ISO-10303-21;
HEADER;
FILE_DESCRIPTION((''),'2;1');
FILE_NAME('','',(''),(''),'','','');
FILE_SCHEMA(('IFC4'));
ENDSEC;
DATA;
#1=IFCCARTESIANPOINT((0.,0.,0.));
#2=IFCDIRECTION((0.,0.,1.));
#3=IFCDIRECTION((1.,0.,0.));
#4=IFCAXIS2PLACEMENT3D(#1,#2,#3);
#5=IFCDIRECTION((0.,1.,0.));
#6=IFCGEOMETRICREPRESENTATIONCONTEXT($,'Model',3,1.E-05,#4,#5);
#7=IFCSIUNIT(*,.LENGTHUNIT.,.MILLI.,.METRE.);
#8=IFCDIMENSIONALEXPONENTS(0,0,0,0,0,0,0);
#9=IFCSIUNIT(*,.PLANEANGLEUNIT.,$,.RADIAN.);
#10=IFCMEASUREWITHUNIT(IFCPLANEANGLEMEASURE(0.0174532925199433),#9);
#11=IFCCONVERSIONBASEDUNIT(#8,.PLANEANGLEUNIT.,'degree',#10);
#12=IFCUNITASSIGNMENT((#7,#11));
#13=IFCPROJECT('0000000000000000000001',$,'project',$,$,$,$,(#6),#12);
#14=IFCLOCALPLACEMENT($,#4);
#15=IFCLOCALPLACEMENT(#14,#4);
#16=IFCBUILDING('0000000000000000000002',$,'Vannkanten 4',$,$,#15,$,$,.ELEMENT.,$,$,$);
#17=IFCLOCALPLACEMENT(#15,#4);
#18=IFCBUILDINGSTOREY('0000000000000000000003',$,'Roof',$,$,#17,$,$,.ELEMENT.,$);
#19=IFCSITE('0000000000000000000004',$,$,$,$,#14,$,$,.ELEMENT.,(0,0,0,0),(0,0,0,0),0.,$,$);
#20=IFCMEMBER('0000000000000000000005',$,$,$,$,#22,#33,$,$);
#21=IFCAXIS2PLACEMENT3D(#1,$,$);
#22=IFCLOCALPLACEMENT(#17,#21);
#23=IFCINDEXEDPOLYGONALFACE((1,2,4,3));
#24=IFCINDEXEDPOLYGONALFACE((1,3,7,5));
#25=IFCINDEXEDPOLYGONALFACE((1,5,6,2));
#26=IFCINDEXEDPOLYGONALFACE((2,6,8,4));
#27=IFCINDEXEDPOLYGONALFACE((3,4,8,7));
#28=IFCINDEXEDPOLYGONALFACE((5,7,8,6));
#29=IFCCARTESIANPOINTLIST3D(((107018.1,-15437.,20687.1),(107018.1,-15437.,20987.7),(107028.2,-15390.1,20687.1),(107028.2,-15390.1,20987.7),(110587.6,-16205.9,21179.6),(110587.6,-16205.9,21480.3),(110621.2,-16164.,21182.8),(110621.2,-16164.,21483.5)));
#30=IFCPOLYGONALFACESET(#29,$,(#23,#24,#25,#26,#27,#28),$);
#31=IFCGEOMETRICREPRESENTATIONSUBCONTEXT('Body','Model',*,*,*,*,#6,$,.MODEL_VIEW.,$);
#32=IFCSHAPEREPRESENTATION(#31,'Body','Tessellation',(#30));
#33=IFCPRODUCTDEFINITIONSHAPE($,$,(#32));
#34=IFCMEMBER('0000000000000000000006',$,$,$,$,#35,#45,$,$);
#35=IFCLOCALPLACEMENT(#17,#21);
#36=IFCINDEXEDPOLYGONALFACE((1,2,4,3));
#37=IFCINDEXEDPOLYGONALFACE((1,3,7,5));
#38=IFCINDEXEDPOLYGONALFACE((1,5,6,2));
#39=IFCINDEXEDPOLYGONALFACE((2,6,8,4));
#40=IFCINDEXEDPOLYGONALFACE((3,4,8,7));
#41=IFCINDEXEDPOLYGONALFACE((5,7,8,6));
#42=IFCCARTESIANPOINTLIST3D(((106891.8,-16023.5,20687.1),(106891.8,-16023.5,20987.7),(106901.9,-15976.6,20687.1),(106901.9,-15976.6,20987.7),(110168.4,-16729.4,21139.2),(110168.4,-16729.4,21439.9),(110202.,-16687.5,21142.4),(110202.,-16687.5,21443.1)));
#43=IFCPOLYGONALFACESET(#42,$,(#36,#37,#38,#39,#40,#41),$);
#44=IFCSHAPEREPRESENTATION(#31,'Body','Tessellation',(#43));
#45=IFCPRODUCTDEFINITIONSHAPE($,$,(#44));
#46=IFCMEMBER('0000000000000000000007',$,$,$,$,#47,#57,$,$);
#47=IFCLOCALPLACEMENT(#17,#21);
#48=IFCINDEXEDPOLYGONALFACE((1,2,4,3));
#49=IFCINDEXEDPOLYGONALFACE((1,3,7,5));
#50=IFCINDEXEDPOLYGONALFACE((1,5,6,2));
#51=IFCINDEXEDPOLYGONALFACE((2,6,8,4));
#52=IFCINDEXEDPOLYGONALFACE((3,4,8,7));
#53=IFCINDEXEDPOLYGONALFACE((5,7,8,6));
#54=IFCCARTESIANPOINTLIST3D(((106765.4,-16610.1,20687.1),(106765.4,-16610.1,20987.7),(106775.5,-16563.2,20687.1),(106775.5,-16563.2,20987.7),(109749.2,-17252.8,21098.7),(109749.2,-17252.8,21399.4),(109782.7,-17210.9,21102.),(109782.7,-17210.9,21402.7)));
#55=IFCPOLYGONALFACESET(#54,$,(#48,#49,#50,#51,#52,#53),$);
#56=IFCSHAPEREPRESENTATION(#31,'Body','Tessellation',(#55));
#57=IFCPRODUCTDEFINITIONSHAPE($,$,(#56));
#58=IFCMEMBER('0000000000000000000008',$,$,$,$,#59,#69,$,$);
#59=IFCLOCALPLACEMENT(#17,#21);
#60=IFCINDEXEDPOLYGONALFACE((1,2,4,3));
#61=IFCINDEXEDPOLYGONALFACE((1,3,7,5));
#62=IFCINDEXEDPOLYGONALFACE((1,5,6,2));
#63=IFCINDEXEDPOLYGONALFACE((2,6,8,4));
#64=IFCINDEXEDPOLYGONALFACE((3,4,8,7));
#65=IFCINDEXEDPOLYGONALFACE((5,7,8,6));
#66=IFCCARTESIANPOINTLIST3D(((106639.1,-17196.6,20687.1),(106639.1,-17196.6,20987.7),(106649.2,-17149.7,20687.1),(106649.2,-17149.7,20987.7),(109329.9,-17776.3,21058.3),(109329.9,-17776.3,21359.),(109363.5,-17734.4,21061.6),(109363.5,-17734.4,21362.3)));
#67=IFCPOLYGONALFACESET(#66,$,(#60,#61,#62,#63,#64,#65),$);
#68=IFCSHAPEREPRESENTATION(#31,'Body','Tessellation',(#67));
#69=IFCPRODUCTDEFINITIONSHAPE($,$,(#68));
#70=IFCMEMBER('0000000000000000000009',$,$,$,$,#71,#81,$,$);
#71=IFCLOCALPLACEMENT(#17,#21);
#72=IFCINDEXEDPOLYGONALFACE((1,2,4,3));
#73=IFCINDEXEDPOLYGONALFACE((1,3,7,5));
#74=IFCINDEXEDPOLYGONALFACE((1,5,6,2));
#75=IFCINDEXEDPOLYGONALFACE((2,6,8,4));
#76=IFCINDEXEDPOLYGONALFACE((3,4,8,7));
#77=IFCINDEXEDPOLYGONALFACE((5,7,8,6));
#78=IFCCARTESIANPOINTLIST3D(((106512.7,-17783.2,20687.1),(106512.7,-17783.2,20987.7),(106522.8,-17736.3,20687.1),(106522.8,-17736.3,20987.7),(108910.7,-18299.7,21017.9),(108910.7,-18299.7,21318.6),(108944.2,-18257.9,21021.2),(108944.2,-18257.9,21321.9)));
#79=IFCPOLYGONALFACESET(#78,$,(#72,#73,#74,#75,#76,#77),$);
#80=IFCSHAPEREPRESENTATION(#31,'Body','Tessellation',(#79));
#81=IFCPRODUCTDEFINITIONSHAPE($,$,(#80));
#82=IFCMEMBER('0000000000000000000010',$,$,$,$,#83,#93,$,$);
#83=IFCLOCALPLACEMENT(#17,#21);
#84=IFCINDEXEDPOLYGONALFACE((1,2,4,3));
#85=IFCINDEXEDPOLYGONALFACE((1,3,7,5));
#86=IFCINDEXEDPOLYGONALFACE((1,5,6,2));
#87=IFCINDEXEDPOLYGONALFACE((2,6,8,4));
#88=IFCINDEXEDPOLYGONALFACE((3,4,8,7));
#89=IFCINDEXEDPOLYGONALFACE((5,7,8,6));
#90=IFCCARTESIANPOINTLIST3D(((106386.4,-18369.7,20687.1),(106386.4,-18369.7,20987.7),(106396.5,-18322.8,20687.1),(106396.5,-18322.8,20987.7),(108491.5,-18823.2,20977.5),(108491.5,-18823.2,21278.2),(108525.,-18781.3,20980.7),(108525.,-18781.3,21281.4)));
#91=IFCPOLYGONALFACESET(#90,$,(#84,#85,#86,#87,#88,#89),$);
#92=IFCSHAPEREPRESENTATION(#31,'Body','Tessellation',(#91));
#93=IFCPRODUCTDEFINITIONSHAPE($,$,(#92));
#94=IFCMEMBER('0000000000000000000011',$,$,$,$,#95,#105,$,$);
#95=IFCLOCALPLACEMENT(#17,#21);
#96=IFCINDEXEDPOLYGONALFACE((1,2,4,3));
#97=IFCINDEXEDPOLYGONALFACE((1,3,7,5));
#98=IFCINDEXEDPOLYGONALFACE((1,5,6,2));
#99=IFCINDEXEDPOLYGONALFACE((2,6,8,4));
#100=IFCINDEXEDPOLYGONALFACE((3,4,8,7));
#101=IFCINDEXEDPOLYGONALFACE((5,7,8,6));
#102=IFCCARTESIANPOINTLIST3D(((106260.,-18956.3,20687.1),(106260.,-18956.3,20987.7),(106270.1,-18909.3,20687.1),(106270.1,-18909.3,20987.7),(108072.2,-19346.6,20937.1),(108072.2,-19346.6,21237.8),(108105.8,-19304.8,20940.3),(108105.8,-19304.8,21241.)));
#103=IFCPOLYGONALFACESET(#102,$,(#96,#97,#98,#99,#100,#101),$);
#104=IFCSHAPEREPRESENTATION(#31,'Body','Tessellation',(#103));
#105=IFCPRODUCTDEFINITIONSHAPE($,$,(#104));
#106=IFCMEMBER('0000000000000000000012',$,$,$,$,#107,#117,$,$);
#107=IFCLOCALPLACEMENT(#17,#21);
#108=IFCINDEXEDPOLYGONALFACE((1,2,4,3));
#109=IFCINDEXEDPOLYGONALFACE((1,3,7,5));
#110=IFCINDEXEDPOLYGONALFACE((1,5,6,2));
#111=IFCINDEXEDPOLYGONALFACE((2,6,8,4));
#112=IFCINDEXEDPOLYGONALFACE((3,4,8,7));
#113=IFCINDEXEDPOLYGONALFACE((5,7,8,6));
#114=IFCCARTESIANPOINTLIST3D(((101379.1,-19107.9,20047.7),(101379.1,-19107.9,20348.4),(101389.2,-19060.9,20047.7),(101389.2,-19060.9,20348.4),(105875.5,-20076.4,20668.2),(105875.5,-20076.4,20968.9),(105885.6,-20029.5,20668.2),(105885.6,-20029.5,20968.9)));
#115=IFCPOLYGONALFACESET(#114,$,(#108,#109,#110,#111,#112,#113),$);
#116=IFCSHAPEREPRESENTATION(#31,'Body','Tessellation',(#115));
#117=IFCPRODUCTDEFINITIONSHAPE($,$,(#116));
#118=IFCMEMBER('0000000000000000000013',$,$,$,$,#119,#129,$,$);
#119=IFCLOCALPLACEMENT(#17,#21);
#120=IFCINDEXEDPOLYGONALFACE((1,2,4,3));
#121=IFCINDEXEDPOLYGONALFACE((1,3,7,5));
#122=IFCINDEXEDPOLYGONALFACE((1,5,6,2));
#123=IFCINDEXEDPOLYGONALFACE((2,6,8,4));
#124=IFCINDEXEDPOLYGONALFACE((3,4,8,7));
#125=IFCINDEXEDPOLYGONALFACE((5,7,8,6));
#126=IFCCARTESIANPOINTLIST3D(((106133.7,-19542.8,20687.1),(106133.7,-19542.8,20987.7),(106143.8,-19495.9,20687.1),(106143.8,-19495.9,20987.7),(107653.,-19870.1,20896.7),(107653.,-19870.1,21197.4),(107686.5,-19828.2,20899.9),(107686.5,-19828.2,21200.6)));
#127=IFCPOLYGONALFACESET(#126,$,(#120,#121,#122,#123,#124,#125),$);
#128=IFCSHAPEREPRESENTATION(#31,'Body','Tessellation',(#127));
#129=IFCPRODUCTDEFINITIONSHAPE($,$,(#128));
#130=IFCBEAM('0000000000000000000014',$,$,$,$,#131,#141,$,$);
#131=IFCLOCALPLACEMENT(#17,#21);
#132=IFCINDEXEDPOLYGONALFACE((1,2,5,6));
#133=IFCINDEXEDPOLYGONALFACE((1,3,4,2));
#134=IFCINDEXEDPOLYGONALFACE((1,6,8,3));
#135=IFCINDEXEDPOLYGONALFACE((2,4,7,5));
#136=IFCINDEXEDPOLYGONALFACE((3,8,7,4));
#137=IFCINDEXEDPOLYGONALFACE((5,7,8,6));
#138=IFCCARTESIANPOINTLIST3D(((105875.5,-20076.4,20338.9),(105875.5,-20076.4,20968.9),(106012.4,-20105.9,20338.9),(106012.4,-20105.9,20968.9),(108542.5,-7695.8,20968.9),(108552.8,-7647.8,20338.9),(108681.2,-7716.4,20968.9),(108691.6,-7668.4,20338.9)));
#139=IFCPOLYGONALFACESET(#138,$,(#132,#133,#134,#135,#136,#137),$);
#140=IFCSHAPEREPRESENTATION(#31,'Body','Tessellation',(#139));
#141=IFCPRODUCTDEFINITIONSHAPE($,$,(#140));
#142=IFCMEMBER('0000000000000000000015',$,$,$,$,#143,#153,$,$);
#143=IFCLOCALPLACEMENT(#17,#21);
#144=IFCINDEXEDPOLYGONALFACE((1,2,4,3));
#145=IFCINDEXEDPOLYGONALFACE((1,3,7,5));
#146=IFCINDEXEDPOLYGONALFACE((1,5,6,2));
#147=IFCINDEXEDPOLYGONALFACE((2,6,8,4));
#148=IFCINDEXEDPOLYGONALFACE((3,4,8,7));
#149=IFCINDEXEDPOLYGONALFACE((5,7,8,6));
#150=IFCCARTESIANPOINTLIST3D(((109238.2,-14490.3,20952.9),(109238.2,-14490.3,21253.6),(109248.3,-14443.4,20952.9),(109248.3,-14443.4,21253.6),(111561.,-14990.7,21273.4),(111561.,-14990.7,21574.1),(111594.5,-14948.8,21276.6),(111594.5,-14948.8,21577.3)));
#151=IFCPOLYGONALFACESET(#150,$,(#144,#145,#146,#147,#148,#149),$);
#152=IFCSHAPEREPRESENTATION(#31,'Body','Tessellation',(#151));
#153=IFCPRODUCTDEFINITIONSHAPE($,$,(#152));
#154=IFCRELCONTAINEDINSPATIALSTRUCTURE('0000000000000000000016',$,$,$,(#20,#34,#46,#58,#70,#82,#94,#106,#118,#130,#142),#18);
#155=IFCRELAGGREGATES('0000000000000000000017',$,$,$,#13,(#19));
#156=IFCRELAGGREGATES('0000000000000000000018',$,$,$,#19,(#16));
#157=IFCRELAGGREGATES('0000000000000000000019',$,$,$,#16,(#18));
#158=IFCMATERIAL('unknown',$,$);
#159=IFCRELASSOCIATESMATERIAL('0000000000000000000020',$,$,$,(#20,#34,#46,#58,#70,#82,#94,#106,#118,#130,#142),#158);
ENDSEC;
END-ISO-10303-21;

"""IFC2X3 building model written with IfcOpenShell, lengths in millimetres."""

from ifc_helpers import new_model, entity, si_unit, converted_unit, direction, frame, origin_with_axes, place, context, subcontext, project, spatial, polyline, segment, composite_curve, outline, extrude, clip, halfspace, material, element, save


model = new_model("IFC2X3")

# Units and contexts
model_context = context("Model", 3, precision=1e-05, world=origin_with_axes(), true_north=direction((0.0, 1.0, 0.0)))
body_context = subcontext(model_context, "Body", "Model", "MODEL_VIEW")
ifc_project = project(units=[si_unit("LENGTHUNIT", "METRE", prefix="MILLI"), converted_unit("PLANEANGLEUNIT", "degree", entity("IfcPlaneAngleMeasure", 0.0174532925199433), si_unit("PLANEANGLEUNIT", "RADIAN"), dimensions=[0, 0, 0, 0, 0, 0, 0])], contexts=[model_context])

# Site, building, storey
site_placement = place(None, origin_with_axes())
site = spatial("IfcSite", under=ifc_project, at=site_placement, CompositionType="ELEMENT", RefLatitude=(0, 0, 0, 0), RefLongitude=(0, 0, 0, 0), RefElevation=0.0)
building_placement = place(site_placement, origin_with_axes())
building = spatial("IfcBuilding", under=site, at=building_placement, Name="Vannkanten 4", CompositionType="ELEMENT")
storey_placement = place(building_placement, origin_with_axes())
storey = spatial("IfcBuildingStorey", under=building, at=storey_placement, Name="Roof", CompositionType="ELEMENT")

# Members
ifc_material = material(Name="unknown")
member_1_placement = place(storey_placement, frame((107023.2, -15413.5, 20837.4), z_axis=(0.968803, -0.208692, 0.133675), x_axis=(0.210582, 0.977576, 0.0)))
element("IfcMember", 1, at=member_1_placement, inside=storey, material=ifc_material, context=body_context, shape_type="Clipping", body=[
    clip(clip(extrude(outline(composite_curve([segment(polyline([(-24.0, -149.0), (-24.0, 149.0), (24.0, 149.0), (24.0, -149.0), (-24.0, -149.0)]), True, "CONTINUOUS")], self_intersect=False)), frame((0.0, 0.0, -1894.5), z_axis=(0.0, 0.0, 1.0), x_axis=(1.0, 0.0, 0.0)), (0.0, 0.0, 1.0), 7497.7), halfspace(frame((-24.0, 149.0, 20.1), z_axis=(0.0, -0.133675, 0.991025), x_axis=(0.0, 0.991025, 0.133675)), True)), halfspace(frame((24.0, 149.0, 3728.8), z_axis=(0.446741, 0.119594, -0.886634), x_axis=(-0.893044, 0.0, -0.44997)), True)),
])
member_2_placement = place(storey_placement, frame((106896.8, -16000.1, 20837.4), z_axis=(0.968803, -0.208692, 0.133675), x_axis=(0.210582, 0.977576, 0.0)))
element("IfcMember", 2, at=member_2_placement, inside=storey, material=ifc_material, context=body_context, shape_type="Clipping", body=[
    clip(clip(extrude(outline(composite_curve([segment(polyline([(-24.0, -149.0), (-24.0, 149.0), (24.0, 149.0), (24.0, -149.0), (-24.0, -149.0)]), True, "CONTINUOUS")], self_intersect=False)), frame((0.0, 0.0, -1743.4), z_axis=(0.0, 0.0, 1.0), x_axis=(1.0, 0.0, 0.0)), (0.0, 0.0, 1.0), 6893.1), halfspace(frame((-24.0, 149.0, 20.1), z_axis=(0.0, -0.133675, 0.991025), x_axis=(0.0, 0.991025, 0.133675)), True)), halfspace(frame((24.0, 149.0, 3426.4), z_axis=(0.446741, 0.119594, -0.886634), x_axis=(-0.893044, 0.0, -0.44997)), True)),
])
member_3_placement = place(storey_placement, frame((106770.5, -16586.6, 20837.4), z_axis=(0.968803, -0.208692, 0.133675), x_axis=(0.210582, 0.977576, 0.0)))
element("IfcMember", 3, at=member_3_placement, inside=storey, material=ifc_material, context=body_context, shape_type="Clipping", body=[
    clip(clip(extrude(outline(composite_curve([segment(polyline([(-24.0, -149.0), (-24.0, 149.0), (24.0, 149.0), (24.0, -149.0), (-24.0, -149.0)]), True, "CONTINUOUS")], self_intersect=False)), frame((0.0, 0.0, -1592.2), z_axis=(0.0, 0.0, 1.0), x_axis=(1.0, 0.0, 0.0)), (0.0, 0.0, 1.0), 6288.4), halfspace(frame((-24.0, 149.0, 20.1), z_axis=(0.0, -0.133675, 0.991025), x_axis=(0.0, 0.991025, 0.133675)), True)), halfspace(frame((24.0, 149.0, 3124.1), z_axis=(0.446741, 0.119594, -0.886634), x_axis=(-0.893044, 0.0, -0.44997)), True)),
])
member_4_placement = place(storey_placement, frame((106644.1, -17173.2, 20837.4), z_axis=(0.968803, -0.208692, 0.133675), x_axis=(0.210582, 0.977576, 0.0)))
element("IfcMember", 4, at=member_4_placement, inside=storey, material=ifc_material, context=body_context, shape_type="Clipping", body=[
    clip(clip(extrude(outline(composite_curve([segment(polyline([(-24.0, -149.0), (-24.0, 149.0), (24.0, 149.0), (24.0, -149.0), (-24.0, -149.0)]), True, "CONTINUOUS")], self_intersect=False)), frame((0.0, 0.0, -1441.0), z_axis=(0.0, 0.0, 1.0), x_axis=(1.0, 0.0, 0.0)), (0.0, 0.0, 1.0), 5683.8), halfspace(frame((-24.0, 149.0, 20.1), z_axis=(0.0, -0.133675, 0.991025), x_axis=(0.0, 0.991025, 0.133675)), True)), halfspace(frame((24.0, 149.0, 2821.8), z_axis=(0.446741, 0.119594, -0.886634), x_axis=(-0.893044, 0.0, -0.44997)), True)),
])
member_5_placement = place(storey_placement, frame((106517.8, -17759.7, 20837.4), z_axis=(0.968803, -0.208692, 0.133675), x_axis=(0.210582, 0.977576, 0.0)))
element("IfcMember", 5, at=member_5_placement, inside=storey, material=ifc_material, context=body_context, shape_type="Clipping", body=[
    clip(clip(extrude(outline(composite_curve([segment(polyline([(-24.0, -149.0), (-24.0, 149.0), (24.0, 149.0), (24.0, -149.0), (-24.0, -149.0)]), True, "CONTINUOUS")], self_intersect=False)), frame((0.0, 0.0, -1289.9), z_axis=(0.0, 0.0, 1.0), x_axis=(1.0, 0.0, 0.0)), (0.0, 0.0, 1.0), 5079.2), halfspace(frame((-24.0, 149.0, 20.1), z_axis=(0.0, -0.133675, 0.991025), x_axis=(0.0, 0.991025, 0.133675)), True)), halfspace(frame((24.0, 149.0, 2519.5), z_axis=(0.446741, 0.119594, -0.886634), x_axis=(-0.893044, 0.0, -0.44997)), True)),
])
member_6_placement = place(storey_placement, frame((106391.4, -18346.3, 20837.4), z_axis=(0.968803, -0.208692, 0.133675), x_axis=(0.210582, 0.977576, 0.0)))
element("IfcMember", 6, at=member_6_placement, inside=storey, material=ifc_material, context=body_context, shape_type="Clipping", body=[
    clip(clip(extrude(outline(composite_curve([segment(polyline([(-24.0, -149.0), (-24.0, 149.0), (24.0, 149.0), (24.0, -149.0), (-24.0, -149.0)]), True, "CONTINUOUS")], self_intersect=False)), frame((0.0, 0.0, -1138.7), z_axis=(0.0, 0.0, 1.0), x_axis=(1.0, 0.0, 0.0)), (0.0, 0.0, 1.0), 4474.5), halfspace(frame((-24.0, 149.0, 20.1), z_axis=(0.0, -0.133675, 0.991025), x_axis=(0.0, 0.991025, 0.133675)), True)), halfspace(frame((24.0, 149.0, 2217.2), z_axis=(0.446741, 0.119594, -0.886634), x_axis=(-0.893044, 0.0, -0.44997)), True)),
])
member_7_placement = place(storey_placement, frame((106265.1, -18932.8, 20837.4), z_axis=(0.968803, -0.208692, 0.133675), x_axis=(0.210582, 0.977576, 0.0)))
element("IfcMember", 7, at=member_7_placement, inside=storey, material=ifc_material, context=body_context, shape_type="Clipping", body=[
    clip(clip(extrude(outline(composite_curve([segment(polyline([(-24.0, -149.0), (-24.0, 149.0), (24.0, 149.0), (24.0, -149.0), (-24.0, -149.0)]), True, "CONTINUOUS")], self_intersect=False)), frame((0.0, 0.0, -987.6), z_axis=(0.0, 0.0, 1.0), x_axis=(1.0, 0.0, 0.0)), (0.0, 0.0, 1.0), 3869.9), halfspace(frame((-24.0, 149.0, 20.1), z_axis=(0.0, -0.133675, 0.991025), x_axis=(0.0, 0.991025, 0.133675)), True)), halfspace(frame((24.0, 149.0, 1914.9), z_axis=(0.446741, 0.119594, -0.886634), x_axis=(-0.893044, 0.0, -0.44997)), True)),
])
member_8_placement = place(storey_placement, frame((105880.6, -20053.0, 20818.5), z_axis=(-0.968803, 0.208692, -0.133675), x_axis=(-0.210582, -0.977576, 0.0)))
element("IfcMember", 8, at=member_8_placement, inside=storey, material=ifc_material, context=body_context, shape_type="Clipping", body=[
    clip(clip(extrude(outline(composite_curve([segment(polyline([(-24.0, -149.0), (-24.0, 149.0), (24.0, 149.0), (24.0, -149.0), (-24.0, -149.0)]), True, "CONTINUOUS")], self_intersect=False)), frame((0.0, 0.0, -2360.8), z_axis=(0.0, 0.0, 1.0), x_axis=(1.0, 0.0, 0.0)), (0.0, 0.0, 1.0), 9362.9), halfspace(frame((-24.0, 149.0, -20.1), z_axis=(0.0, 0.133675, 0.991025), x_axis=(0.0, 0.991025, -0.133675)), True)), halfspace(frame((24.0, 149.0, 4621.1), z_axis=(0.000083, -0.133675, -0.991025), x_axis=(0.0, -0.991025, 0.133675)), True)),
])
member_9_placement = place(storey_placement, frame((106138.7, -19519.4, 20837.4), z_axis=(0.968803, -0.208692, 0.133675), x_axis=(0.210582, 0.977576, 0.0)))
element("IfcMember", 9, at=member_9_placement, inside=storey, material=ifc_material, context=body_context, shape_type="Clipping", body=[
    clip(clip(extrude(outline(composite_curve([segment(polyline([(-24.0, -149.0), (-24.0, 149.0), (24.0, 149.0), (24.0, -149.0), (-24.0, -149.0)]), True, "CONTINUOUS")], self_intersect=False)), frame((0.0, 0.0, -836.4), z_axis=(0.0, 0.0, 1.0), x_axis=(1.0, 0.0, 0.0)), (0.0, 0.0, 1.0), 3265.3), halfspace(frame((-24.0, 149.0, 20.1), z_axis=(0.0, -0.133675, 0.991025), x_axis=(0.0, 0.991025, 0.133675)), True)), halfspace(frame((24.0, 149.0, 1612.5), z_axis=(0.446741, 0.119594, -0.886634), x_axis=(-0.893044, 0.0, -0.44997)), True)),
])

# Beam
beam_1_placement = place(storey_placement, frame((105943.9, -20091.2, 20653.9), z_axis=(0.210582, 0.977576, 0.0), x_axis=(-0.977576, 0.210582, 0.0)))
element("IfcBeam", 10, at=beam_1_placement, inside=storey, material=ifc_material, context=body_context, shape_type="Clipping", body=[
    clip(extrude(outline(composite_curve([segment(polyline([(-70.0, 315.0), (-70.0, -315.0), (70.0, -315.0), (70.0, 315.0), (-70.0, 315.0)]), True, "CONTINUOUS")], self_intersect=False)), frame((0.0, 0.0, 0.0), z_axis=(0.0, 0.0, 1.0), x_axis=(1.0, 0.0, 0.0)), (0.0, 0.0, 1.0), 19084.2), halfspace(frame((-70.0, -315.0, 12722.8), z_axis=(-0.064556, -0.077476, -0.994902), x_axis=(0.0, -0.996982, 0.077638)), True)),
])

# Member
member_10_placement = place(storey_placement, frame((111577.7, -14969.7, 21425.4), z_axis=(-0.968803, 0.208692, -0.133675), x_axis=(-0.210582, -0.977576, 0.0)))
element("IfcMember", 11, at=member_10_placement, inside=storey, material=ifc_material, context=body_context, shape_type="Clipping", body=[
    clip(clip(extrude(outline(composite_curve([segment(polyline([(-24.0, -149.0), (-24.0, 149.0), (24.0, 149.0), (24.0, -149.0), (-24.0, -149.0)]), True, "CONTINUOUS")], self_intersect=False)), frame((0.0, 0.0, -1263.2), z_axis=(0.0, 0.0, 1.0), x_axis=(1.0, 0.0, 0.0)), (0.0, 0.0, 1.0), 4923.9), halfspace(frame((-24.0, 149.0, -32.2), z_axis=(-0.446741, 0.119594, 0.886634), x_axis=(0.893044, 0.0, 0.44997)), True)), halfspace(frame((24.0, 149.0, 2389.6), z_axis=(0.0, -0.133675, -0.991025), x_axis=(0.0, -0.991025, 0.133675)), True)),
])

save(model, "model.ifc")
